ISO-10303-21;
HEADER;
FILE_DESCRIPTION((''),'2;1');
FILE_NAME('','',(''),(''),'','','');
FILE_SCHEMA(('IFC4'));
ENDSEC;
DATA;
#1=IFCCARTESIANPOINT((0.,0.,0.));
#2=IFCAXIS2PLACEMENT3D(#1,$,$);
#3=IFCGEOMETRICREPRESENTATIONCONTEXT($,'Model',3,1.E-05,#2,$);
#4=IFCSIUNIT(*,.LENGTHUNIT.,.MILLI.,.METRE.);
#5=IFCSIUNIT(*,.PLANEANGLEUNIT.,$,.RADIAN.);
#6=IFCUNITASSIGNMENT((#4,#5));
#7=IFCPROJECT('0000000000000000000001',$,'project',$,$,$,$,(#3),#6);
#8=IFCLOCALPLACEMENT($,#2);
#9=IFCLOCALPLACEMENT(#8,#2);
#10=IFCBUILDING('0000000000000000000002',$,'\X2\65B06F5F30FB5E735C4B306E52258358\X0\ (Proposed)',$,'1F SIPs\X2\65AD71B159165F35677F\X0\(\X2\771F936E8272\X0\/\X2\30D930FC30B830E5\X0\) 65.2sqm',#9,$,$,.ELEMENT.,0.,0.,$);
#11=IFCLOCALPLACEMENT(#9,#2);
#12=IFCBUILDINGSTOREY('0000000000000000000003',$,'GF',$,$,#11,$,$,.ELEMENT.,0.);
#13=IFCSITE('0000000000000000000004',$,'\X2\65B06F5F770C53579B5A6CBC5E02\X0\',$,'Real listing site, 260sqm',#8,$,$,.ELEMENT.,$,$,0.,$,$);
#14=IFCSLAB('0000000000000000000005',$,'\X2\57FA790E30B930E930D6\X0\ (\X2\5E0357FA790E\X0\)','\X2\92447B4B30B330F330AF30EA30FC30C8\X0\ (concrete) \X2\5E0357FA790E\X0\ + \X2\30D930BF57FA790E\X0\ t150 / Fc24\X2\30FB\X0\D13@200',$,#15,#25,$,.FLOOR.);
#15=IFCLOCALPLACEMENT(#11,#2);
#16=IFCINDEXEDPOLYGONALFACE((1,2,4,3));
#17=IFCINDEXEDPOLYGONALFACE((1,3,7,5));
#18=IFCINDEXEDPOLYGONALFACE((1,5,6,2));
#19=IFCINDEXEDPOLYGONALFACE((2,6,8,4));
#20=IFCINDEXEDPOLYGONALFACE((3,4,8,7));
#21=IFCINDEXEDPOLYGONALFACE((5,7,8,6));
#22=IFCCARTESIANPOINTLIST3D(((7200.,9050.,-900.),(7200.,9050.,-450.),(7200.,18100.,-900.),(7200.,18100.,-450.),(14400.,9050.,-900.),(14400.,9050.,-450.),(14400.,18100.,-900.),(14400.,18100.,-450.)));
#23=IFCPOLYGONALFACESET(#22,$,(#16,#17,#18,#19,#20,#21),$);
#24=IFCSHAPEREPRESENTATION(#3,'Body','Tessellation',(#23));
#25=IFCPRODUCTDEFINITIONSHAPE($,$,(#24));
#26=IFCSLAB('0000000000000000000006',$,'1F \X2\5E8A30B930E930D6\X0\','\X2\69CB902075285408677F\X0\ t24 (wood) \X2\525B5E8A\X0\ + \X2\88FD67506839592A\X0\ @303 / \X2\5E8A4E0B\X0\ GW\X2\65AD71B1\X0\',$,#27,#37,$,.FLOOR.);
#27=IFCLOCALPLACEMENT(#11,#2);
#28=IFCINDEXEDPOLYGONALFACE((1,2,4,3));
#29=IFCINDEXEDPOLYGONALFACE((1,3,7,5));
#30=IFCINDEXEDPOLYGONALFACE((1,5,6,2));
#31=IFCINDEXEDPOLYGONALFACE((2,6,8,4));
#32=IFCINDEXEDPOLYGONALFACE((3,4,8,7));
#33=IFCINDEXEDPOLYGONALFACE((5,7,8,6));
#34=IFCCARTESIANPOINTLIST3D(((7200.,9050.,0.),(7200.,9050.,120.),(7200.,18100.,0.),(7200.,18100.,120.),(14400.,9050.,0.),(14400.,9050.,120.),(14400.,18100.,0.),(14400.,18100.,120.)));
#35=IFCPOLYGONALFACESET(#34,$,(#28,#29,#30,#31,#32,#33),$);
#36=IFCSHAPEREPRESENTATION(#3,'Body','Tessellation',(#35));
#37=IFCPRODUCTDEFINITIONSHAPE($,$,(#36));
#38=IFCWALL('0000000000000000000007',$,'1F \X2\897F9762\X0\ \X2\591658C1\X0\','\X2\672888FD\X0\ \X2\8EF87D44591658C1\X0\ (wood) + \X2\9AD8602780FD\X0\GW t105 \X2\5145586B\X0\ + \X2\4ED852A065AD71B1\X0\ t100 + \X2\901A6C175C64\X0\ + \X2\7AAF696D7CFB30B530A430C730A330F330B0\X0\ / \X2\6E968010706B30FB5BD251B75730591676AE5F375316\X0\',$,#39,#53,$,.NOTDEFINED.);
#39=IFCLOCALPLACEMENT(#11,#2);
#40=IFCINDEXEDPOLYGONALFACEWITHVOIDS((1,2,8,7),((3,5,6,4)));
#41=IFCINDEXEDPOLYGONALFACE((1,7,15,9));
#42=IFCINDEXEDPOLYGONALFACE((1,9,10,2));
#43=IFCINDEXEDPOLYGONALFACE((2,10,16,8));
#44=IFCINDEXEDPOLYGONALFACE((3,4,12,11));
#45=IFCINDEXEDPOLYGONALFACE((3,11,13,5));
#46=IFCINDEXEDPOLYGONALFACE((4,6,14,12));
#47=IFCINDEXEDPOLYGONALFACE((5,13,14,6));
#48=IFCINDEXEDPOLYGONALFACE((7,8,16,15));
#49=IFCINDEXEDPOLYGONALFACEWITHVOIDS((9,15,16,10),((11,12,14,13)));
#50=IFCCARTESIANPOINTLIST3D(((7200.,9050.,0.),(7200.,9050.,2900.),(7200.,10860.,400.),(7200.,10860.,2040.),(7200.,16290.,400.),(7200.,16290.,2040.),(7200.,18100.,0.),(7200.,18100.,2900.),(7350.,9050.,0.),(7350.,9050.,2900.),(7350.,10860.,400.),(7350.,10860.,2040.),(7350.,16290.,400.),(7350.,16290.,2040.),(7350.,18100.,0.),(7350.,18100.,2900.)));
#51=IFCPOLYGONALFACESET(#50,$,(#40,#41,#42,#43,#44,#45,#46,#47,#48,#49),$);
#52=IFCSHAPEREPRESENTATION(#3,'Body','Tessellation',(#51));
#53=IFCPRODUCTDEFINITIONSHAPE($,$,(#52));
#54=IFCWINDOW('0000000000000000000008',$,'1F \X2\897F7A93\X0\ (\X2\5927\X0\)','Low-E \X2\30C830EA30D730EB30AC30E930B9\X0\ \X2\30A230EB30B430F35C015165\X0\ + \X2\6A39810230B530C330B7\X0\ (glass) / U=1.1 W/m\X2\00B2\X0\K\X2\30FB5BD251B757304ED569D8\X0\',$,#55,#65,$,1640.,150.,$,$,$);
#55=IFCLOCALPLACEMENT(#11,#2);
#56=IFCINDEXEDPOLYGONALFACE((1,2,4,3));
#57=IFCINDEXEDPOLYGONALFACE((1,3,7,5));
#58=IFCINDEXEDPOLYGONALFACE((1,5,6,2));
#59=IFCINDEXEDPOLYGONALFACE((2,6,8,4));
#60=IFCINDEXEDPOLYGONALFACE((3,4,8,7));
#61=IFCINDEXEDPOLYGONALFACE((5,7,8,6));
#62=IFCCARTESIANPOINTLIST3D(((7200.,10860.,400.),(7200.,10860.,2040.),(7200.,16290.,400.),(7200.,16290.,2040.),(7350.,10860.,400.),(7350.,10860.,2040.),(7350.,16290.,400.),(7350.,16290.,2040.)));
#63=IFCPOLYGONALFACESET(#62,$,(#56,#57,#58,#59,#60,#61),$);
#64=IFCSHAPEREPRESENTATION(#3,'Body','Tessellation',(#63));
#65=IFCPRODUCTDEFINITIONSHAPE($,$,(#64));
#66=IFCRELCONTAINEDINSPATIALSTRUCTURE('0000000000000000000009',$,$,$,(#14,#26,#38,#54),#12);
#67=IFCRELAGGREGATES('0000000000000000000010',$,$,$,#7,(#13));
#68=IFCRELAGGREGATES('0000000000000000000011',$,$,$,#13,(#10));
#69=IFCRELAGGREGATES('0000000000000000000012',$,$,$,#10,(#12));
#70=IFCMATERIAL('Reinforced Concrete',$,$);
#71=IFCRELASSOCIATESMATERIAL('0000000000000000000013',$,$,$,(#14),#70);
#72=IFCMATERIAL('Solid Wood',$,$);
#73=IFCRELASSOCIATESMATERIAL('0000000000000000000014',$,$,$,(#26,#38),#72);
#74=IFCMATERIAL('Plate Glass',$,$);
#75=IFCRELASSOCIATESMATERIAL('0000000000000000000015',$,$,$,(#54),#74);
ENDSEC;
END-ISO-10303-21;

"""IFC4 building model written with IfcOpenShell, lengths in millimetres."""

from ifc_helpers import new_model, si_unit, frame, frame_2d, origin, place, context, project, spatial, rectangle, extrude, material, element, fill, save


model = new_model("IFC4")

# Units and contexts
model_context = context("Model", 3, precision=1e-05, world=origin())
ifc_project = project(units=[si_unit("LENGTHUNIT", "METRE", prefix="MILLI"), si_unit("PLANEANGLEUNIT", "RADIAN")], contexts=[model_context])

# Site, building, storey
site_placement = place(None, origin())
site = spatial("IfcSite", under=ifc_project, at=site_placement, Name="新潟県南魚沼市", ObjectType="Real listing site, 260sqm", CompositionType="ELEMENT", RefElevation=0.0)
building_placement = place(site_placement, origin())
building = spatial("IfcBuilding", under=site, at=building_placement, Name="新潟・平屋の別荘 (Proposed)", ObjectType="1F SIPs断熱外張板(真鍮色/ベージュ) 65.2sqm", CompositionType="ELEMENT", ElevationOfRefHeight=0.0, ElevationOfTerrain=0.0)
storey_placement = place(building_placement, origin())
storey = spatial("IfcBuildingStorey", under=building, at=storey_placement, Name="GF", CompositionType="ELEMENT", Elevation=0.0)

# Shared definitions
ifc_material_1 = material(Name="Solid Wood")

# Slabs
ifc_material_2 = material(Name="Reinforced Concrete")
slab_1_placement = place(storey_placement, frame((3600.0, 4525.0, -450.0)))
element("IfcSlab", 1, at=slab_1_placement, inside=storey, material=ifc_material_2, Name="基礎スラブ (布基礎)", Description="鉄筋コンクリート (concrete) 布基礎 + ベタ基礎 t150 / Fc24・D13@200", PredefinedType="FLOOR", context=model_context, shape_type="SweptSolid", body=[
    extrude(rectangle(XDim=7200.0, YDim=9050.0, at=frame_2d((3600.0, 4525.0))), frame((3600.0, 4525.0, -450.0)), (0.0, 0.0, 1.0), 450.0),
])
slab_2_placement = place(storey_placement, frame((3600.0, 4525.0, 0.0)))
element("IfcSlab", 2, at=slab_2_placement, inside=storey, material=ifc_material_1, Name="1F 床スラブ", Description="構造用合板 t24 (wood) 剛床 + 製材根太 @303 / 床下 GW断熱", PredefinedType="FLOOR", context=model_context, shape_type="SweptSolid", body=[
    extrude(rectangle(XDim=7200.0, YDim=9050.0, at=frame_2d((3600.0, 4525.0))), frame((3600.0, 4525.0, 0.0)), (0.0, 0.0, 1.0), 120.0),
])

# Shared definitions
ifc_material_3 = material(Name="Plate Glass")

# Wall, opening, window
wall_1_placement = place(storey_placement, frame((3600.0, 4525.0, 0.0)))
wall_1 = element("IfcWall", 3, at=wall_1_placement, inside=storey, material=ifc_material_1, Name="1F 西面 外壁", Description="木製 軸組外壁 (wood) + 高性能GW t105 充填 + 付加断熱 t100 + 通気層 + 窯業系サイディング / 準耐火・寒冷地外皮強化", PredefinedType="NOTDEFINED", context=model_context, shape_type="SweptSolid", body=[
    extrude(rectangle(XDim=150.0, YDim=9050.0, at=frame_2d((75.0, 4525.0))), frame((3600.0, 4525.0, 0.0)), (0.0, 0.0, 1.0), 2900.0),
])
opening_1_placement = place(storey_placement, frame((3600.0, 5430.0, 200.0)))
opening_1 = element("IfcOpeningElement", 4, at=opening_1_placement, cuts=wall_1, PredefinedType="NOTDEFINED", context=model_context, shape_type="SweptSolid", body=[
    extrude(rectangle(XDim=150.0, YDim=5430.0, at=frame_2d((75.0, 2715.0))), frame((3600.0, 5430.0, 200.0)), (0.0, 0.0, 1.0), 1640.0),
])
window_1_placement = place(storey_placement, frame((3600.0, 5430.0, 200.0)))
window_1 = element("IfcWindow", 5, at=window_1_placement, inside=storey, material=ifc_material_3, Name="1F 西窓 (大)", Description="Low-E トリプルガラス アルゴン封入 + 樹脂サッシ (glass) / U=1.1 W/m²K・寒冷地仕様", OverallHeight=1640.0, OverallWidth=150.0, context=model_context, shape_type="SweptSolid", body=[
    extrude(rectangle(XDim=150.0, YDim=5430.0, at=frame_2d((75.0, 2715.0))), frame((3600.0, 5430.0, 200.0)), (0.0, 0.0, 1.0), 1640.0),
])
fill(opening_1, window_1)

save(model, "model.ifc")
